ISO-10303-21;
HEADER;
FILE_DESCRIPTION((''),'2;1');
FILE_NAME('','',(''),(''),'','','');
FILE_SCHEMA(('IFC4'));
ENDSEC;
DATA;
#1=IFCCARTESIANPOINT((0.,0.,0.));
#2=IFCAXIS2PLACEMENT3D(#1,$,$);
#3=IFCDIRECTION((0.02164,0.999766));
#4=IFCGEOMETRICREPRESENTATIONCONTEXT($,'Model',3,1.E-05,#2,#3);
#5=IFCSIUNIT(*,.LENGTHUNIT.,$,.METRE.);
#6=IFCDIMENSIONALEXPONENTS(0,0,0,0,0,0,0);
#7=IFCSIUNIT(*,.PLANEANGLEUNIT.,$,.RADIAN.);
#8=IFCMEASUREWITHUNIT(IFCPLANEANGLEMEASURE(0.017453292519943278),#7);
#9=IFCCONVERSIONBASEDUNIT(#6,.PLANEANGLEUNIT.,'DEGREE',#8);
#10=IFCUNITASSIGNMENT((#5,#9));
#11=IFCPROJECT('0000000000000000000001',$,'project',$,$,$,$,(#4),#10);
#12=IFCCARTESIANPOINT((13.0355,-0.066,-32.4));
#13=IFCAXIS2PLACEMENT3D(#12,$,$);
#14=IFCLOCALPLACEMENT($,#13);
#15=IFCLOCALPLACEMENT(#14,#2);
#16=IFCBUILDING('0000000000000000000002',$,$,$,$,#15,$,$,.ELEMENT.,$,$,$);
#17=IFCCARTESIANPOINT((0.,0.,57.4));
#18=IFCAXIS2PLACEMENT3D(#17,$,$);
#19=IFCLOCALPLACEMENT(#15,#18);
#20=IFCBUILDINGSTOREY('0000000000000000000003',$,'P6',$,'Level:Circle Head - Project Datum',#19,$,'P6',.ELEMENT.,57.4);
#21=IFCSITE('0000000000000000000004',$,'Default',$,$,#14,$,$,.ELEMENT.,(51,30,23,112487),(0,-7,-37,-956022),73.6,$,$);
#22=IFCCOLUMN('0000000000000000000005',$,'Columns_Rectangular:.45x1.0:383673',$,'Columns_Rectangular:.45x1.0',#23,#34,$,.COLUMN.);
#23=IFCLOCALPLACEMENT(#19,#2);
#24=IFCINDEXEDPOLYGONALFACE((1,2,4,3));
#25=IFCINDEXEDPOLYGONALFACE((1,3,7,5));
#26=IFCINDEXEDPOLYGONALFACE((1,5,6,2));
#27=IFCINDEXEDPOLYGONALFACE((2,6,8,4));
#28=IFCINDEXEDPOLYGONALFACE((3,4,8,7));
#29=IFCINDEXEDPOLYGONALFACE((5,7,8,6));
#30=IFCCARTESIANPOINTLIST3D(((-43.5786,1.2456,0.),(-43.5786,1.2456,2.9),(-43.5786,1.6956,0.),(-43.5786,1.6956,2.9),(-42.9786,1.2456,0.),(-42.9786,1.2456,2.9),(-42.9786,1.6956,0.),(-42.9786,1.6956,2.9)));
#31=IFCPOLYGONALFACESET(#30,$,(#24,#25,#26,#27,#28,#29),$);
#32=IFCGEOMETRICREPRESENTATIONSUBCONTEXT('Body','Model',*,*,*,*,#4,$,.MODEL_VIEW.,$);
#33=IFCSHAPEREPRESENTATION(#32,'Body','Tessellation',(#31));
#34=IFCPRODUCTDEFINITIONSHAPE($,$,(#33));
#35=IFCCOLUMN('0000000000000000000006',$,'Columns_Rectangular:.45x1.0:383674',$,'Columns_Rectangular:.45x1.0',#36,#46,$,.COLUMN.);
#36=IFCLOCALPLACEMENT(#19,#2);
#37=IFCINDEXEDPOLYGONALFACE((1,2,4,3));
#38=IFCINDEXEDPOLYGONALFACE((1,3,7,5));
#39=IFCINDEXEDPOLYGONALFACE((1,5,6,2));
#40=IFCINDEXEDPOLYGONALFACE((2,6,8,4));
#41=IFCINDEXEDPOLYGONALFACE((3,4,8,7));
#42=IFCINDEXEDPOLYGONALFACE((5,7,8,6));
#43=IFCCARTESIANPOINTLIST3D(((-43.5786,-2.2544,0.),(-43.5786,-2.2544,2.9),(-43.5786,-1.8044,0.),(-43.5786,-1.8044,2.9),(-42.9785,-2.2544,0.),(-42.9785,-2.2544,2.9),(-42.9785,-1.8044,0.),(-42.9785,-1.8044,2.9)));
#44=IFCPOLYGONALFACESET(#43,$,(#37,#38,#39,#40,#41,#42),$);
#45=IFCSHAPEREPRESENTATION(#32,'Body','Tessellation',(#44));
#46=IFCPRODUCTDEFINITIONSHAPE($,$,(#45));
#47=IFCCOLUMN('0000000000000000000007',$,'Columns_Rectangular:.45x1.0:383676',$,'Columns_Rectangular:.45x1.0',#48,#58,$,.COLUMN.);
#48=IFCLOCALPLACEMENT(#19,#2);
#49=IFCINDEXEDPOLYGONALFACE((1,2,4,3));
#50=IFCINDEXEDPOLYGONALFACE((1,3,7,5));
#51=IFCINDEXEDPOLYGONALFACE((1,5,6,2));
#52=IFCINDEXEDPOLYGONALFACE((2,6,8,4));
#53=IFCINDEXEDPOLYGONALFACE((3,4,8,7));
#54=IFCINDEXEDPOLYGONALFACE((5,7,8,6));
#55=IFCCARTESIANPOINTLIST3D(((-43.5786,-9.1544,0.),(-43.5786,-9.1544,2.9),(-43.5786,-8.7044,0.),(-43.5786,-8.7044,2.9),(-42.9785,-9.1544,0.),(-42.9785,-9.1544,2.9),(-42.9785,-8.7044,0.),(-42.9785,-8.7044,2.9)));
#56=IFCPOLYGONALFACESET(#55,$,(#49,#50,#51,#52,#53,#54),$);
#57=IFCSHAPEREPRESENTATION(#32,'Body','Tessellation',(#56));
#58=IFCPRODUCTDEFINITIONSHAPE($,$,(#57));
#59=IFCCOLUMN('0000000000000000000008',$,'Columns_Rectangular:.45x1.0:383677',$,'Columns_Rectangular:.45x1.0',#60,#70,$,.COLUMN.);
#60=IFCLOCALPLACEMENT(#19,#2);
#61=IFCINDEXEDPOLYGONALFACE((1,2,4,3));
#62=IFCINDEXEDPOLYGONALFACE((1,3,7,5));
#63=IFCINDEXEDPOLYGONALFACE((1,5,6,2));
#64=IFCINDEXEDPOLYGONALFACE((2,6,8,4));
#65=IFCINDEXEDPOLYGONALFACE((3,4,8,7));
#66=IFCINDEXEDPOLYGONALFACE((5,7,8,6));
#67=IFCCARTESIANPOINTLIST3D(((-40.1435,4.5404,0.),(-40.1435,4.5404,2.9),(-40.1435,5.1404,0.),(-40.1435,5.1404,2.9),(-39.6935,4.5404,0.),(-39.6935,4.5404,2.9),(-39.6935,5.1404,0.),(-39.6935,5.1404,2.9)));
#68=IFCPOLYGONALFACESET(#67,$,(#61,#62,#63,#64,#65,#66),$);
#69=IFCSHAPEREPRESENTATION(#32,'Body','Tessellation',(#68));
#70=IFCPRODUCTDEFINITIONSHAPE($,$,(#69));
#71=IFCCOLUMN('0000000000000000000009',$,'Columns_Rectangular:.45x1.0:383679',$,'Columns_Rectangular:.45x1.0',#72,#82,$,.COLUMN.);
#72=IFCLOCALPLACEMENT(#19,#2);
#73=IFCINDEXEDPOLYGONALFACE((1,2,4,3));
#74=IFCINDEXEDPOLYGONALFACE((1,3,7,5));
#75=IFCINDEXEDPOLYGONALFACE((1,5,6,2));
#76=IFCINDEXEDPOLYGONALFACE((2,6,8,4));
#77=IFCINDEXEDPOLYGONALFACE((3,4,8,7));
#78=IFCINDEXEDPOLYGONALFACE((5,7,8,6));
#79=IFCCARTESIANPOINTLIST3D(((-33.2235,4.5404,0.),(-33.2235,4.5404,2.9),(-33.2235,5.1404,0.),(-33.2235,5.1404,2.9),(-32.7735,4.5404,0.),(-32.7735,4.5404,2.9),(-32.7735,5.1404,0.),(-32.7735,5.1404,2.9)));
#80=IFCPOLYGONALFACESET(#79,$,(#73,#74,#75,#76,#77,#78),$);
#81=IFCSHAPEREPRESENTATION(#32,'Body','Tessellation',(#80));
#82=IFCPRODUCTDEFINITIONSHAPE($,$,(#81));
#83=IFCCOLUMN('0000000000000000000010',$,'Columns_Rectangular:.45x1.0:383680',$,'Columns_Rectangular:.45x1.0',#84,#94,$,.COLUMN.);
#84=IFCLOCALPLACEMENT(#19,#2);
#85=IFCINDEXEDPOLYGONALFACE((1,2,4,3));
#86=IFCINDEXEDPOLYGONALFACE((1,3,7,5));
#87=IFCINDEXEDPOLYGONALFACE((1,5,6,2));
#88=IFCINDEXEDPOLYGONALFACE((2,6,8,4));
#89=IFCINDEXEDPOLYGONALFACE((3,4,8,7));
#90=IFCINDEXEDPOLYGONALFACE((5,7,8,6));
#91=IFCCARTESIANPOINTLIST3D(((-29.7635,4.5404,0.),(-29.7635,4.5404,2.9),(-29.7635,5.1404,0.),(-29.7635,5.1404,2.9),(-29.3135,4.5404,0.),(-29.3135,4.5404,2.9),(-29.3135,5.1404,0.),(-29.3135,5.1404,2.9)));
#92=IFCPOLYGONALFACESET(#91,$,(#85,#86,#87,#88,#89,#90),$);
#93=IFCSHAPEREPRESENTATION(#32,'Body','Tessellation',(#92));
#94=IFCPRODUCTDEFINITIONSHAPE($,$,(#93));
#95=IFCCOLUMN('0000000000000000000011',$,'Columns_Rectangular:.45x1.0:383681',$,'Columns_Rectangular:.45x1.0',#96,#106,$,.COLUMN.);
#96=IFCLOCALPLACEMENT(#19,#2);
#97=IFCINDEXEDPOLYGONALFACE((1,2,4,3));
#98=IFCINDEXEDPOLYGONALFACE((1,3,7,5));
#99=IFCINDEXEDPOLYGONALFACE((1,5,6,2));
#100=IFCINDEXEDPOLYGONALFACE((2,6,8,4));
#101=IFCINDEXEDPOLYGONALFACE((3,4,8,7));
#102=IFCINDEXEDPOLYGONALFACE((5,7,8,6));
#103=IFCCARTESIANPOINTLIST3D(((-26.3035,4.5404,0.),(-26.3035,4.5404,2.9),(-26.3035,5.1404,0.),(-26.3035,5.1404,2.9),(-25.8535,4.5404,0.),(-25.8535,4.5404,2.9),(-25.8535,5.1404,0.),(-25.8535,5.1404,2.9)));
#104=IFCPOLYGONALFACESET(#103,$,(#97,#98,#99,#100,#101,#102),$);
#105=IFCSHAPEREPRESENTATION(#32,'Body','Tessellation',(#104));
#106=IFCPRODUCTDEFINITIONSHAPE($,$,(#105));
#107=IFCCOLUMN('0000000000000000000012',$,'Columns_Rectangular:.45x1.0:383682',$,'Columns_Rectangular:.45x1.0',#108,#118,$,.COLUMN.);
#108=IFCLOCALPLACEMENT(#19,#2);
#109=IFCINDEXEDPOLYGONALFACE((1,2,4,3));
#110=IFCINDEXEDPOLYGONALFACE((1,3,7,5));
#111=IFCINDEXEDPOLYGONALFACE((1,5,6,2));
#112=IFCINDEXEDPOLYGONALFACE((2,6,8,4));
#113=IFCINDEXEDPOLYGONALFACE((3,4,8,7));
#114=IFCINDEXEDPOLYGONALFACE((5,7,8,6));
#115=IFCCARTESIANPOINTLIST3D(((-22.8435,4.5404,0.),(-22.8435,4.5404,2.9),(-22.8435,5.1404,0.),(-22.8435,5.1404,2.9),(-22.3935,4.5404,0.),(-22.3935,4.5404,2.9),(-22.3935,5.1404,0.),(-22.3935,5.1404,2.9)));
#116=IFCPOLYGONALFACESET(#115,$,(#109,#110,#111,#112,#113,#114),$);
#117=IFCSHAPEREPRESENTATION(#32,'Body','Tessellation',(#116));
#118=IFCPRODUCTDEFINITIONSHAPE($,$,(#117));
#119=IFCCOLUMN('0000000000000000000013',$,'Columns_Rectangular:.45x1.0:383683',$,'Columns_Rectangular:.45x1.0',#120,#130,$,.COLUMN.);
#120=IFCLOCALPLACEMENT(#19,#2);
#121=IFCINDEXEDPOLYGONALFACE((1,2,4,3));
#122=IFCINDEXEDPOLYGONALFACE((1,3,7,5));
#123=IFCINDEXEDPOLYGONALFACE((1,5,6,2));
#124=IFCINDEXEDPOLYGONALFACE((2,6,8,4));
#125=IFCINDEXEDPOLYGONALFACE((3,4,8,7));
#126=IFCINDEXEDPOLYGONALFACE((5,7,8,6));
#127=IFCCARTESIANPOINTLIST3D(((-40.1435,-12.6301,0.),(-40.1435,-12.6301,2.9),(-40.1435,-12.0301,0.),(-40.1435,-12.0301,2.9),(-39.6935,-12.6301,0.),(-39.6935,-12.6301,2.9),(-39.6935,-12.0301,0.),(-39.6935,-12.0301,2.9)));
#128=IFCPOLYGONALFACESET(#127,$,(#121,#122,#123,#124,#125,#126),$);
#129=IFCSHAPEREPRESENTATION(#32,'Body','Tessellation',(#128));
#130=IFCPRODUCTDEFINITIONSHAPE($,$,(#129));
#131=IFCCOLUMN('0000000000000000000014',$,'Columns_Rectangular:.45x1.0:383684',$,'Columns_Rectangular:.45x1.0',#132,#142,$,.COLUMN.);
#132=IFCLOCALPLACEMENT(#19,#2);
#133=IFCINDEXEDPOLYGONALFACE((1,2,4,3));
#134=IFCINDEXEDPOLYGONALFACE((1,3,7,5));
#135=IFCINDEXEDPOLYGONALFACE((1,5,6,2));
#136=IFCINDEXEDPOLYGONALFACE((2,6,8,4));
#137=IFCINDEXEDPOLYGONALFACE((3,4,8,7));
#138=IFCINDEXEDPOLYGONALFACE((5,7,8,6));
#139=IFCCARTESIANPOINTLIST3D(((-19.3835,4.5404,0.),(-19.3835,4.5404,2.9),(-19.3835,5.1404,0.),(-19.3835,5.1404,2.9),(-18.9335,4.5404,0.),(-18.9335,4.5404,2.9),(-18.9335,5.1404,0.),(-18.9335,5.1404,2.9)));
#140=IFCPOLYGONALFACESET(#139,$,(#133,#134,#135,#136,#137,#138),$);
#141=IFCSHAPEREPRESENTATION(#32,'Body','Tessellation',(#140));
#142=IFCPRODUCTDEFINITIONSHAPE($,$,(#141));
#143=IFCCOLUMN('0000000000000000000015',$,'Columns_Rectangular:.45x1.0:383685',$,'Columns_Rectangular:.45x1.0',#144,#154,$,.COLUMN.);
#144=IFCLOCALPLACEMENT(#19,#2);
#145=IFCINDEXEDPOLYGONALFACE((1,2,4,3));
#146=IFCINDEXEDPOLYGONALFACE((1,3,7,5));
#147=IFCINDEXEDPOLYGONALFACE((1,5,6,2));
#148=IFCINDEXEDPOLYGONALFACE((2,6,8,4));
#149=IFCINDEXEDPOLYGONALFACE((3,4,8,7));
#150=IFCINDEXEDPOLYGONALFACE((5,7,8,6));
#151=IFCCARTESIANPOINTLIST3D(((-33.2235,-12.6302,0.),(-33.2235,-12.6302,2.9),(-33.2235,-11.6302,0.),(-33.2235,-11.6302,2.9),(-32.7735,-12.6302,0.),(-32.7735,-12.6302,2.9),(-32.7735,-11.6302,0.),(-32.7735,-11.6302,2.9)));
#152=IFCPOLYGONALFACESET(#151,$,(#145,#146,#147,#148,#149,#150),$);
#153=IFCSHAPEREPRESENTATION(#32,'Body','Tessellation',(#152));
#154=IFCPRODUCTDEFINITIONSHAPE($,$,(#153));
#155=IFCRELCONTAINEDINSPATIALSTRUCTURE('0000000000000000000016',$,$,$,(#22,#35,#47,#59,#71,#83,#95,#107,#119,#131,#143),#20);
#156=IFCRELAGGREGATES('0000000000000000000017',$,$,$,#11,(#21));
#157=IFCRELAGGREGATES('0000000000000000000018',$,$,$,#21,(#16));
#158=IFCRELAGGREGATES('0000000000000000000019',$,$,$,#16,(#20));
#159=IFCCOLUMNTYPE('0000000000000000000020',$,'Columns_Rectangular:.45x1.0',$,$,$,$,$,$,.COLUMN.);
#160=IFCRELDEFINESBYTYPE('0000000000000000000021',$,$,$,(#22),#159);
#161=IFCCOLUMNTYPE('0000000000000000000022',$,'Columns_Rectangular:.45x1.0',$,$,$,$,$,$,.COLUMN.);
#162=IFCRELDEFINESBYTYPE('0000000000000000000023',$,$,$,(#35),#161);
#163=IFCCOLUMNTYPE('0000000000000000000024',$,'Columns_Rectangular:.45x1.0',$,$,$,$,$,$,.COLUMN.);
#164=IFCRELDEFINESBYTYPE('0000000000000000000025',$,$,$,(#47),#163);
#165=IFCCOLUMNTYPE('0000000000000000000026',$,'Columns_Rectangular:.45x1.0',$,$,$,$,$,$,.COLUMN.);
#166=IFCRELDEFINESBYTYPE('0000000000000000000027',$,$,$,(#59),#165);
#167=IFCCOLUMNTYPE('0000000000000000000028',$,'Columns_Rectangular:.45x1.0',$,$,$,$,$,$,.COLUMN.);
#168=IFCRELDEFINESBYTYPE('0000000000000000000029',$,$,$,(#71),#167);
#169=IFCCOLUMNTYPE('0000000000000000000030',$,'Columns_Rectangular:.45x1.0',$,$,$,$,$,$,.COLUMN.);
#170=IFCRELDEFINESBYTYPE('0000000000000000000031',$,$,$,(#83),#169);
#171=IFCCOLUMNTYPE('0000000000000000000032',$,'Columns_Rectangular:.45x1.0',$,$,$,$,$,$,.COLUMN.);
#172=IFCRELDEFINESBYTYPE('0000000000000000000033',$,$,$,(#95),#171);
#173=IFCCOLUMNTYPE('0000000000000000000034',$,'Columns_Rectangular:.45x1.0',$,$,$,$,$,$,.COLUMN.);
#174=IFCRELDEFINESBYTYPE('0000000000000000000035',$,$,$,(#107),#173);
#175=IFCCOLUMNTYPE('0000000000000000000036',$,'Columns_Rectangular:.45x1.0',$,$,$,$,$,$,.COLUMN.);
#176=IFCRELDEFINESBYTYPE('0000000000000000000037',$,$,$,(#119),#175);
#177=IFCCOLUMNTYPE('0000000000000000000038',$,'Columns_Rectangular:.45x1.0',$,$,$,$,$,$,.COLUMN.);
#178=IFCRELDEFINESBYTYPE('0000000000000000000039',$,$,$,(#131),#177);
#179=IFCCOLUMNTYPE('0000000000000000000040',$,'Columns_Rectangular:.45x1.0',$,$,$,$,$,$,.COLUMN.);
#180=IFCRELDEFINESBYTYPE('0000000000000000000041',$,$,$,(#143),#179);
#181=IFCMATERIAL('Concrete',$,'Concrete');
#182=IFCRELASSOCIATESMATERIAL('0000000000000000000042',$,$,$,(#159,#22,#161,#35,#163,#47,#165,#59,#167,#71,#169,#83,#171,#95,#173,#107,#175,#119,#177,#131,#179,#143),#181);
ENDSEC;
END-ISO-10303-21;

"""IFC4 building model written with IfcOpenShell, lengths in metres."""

from ifc_helpers import new_model, entity, si_unit, converted_unit, direction, frame, origin, place, context, subcontext, project, spatial, indexed_curve, outline, extrude, source, transform, mapped, material, type_object, type_shapes, element, save


model = new_model("IFC4")

# Units and contexts
model_context = context("Model", 3, precision=1e-05, world=origin(), true_north=direction((0.02164, 0.999766)))
body_context = subcontext(model_context, "Body", "Model", "MODEL_VIEW")
ifc_project = project(units=[si_unit("LENGTHUNIT", "METRE"), converted_unit("PLANEANGLEUNIT", "DEGREE", entity("IfcPlaneAngleMeasure", 0.017453292519943278), si_unit("PLANEANGLEUNIT", "RADIAN"), dimensions=[0, 0, 0, 0, 0, 0, 0])], contexts=[model_context])

# Site, building, storey
site_placement = place(None, frame((13.0355, -0.066, -32.4)))
site = spatial("IfcSite", under=ifc_project, at=site_placement, Name="Default", CompositionType="ELEMENT", RefLatitude=(51, 30, 23, 112487), RefLongitude=(0, -7, -37, -956022), RefElevation=73.6)
building_placement = place(site_placement, origin())
building = spatial("IfcBuilding", under=site, at=building_placement, CompositionType="ELEMENT")
storey_placement = place(building_placement, frame((0.0, 0.0, 57.4)))
storey = spatial("IfcBuildingStorey", under=building, at=storey_placement, Name="P6", ObjectType="Level:Circle Head - Project Datum", LongName="P6", CompositionType="ELEMENT", Elevation=57.4)

# Columns
ifc_material = material(Name="Concrete", Category="Concrete")
column_type_1 = type_object("IfcColumnType", Name="Columns_Rectangular:.45x1.0", PredefinedType="COLUMN", material=ifc_material)
shared_shape_1 = source(origin(), body_context, "Body", "SweptSolid", [
    extrude(outline(indexed_curve([(-0.3, -0.225), (0.3, -0.225), (0.3, 0.225), (-0.3, 0.225), (-0.3, -0.225)], self_intersect=False)), frame((-43.2786, 1.4706, 57.4)), (0.0, 0.0, 1.0), 2.9),
])
type_shapes(column_type_1, [shared_shape_1])
column_1_placement = place(storey_placement, frame((0.0, 0.0, -57.4)))
element("IfcColumn", 1, at=column_1_placement, inside=storey, type_object=column_type_1, material=ifc_material, Name="Columns_Rectangular:.45x1.0:383673", ObjectType="Columns_Rectangular:.45x1.0", PredefinedType="COLUMN", context=body_context, shape_type="MappedRepresentation", body=[
    mapped(shared_shape_1, transform((0.0, 0.0, 0.0), scale=1.0)),
])
column_type_2 = type_object("IfcColumnType", Name="Columns_Rectangular:.45x1.0", PredefinedType="COLUMN", material=ifc_material)
shared_shape_2 = source(origin(), body_context, "Body", "SweptSolid", [
    extrude(outline(indexed_curve([(-0.3, -0.225), (0.3, -0.225), (0.3, 0.225), (-0.3, 0.225), (-0.3, -0.225)], self_intersect=False)), frame((-43.2785, -2.0294, 57.4)), (0.0, 0.0, 1.0), 2.9),
])
type_shapes(column_type_2, [shared_shape_2])
column_2_placement = place(storey_placement, frame((0.0, 0.0, -57.4)))
element("IfcColumn", 2, at=column_2_placement, inside=storey, type_object=column_type_2, material=ifc_material, Name="Columns_Rectangular:.45x1.0:383674", ObjectType="Columns_Rectangular:.45x1.0", PredefinedType="COLUMN", context=body_context, shape_type="MappedRepresentation", body=[
    mapped(shared_shape_2, transform((0.0, 0.0, 0.0), scale=1.0)),
])
column_type_3 = type_object("IfcColumnType", Name="Columns_Rectangular:.45x1.0", PredefinedType="COLUMN", material=ifc_material)
shared_shape_3 = source(origin(), body_context, "Body", "SweptSolid", [
    extrude(outline(indexed_curve([(-0.3, -0.225), (0.3, -0.225), (0.3, 0.225), (-0.3, 0.225), (-0.3, -0.225)], self_intersect=False)), frame((-43.2785, -8.9294, 57.4)), (0.0, 0.0, 1.0), 2.9),
])
type_shapes(column_type_3, [shared_shape_3])
column_3_placement = place(storey_placement, frame((0.0, 0.0, -57.4)))
element("IfcColumn", 3, at=column_3_placement, inside=storey, type_object=column_type_3, material=ifc_material, Name="Columns_Rectangular:.45x1.0:383676", ObjectType="Columns_Rectangular:.45x1.0", PredefinedType="COLUMN", context=body_context, shape_type="MappedRepresentation", body=[
    mapped(shared_shape_3, transform((0.0, 0.0, 0.0), scale=1.0)),
])
column_type_4 = type_object("IfcColumnType", Name="Columns_Rectangular:.45x1.0", PredefinedType="COLUMN", material=ifc_material)
shared_shape_4 = source(origin(), body_context, "Body", "SweptSolid", [
    extrude(outline(indexed_curve([(-0.3, -0.225), (0.3, -0.225), (0.3, 0.225), (-0.3, 0.225), (-0.3, -0.225)], self_intersect=False)), frame((-39.9185, 4.8404, 57.4), z_axis=(0.0, 0.0, 1.0), x_axis=(0.0, -1.0, 0.0)), (0.0, 0.0, 1.0), 2.9),
])
type_shapes(column_type_4, [shared_shape_4])
column_4_placement = place(storey_placement, frame((0.0, 0.0, -57.4)))
element("IfcColumn", 4, at=column_4_placement, inside=storey, type_object=column_type_4, material=ifc_material, Name="Columns_Rectangular:.45x1.0:383677", ObjectType="Columns_Rectangular:.45x1.0", PredefinedType="COLUMN", context=body_context, shape_type="MappedRepresentation", body=[
    mapped(shared_shape_4, transform((0.0, 0.0, 0.0), scale=1.0)),
])
column_type_5 = type_object("IfcColumnType", Name="Columns_Rectangular:.45x1.0", PredefinedType="COLUMN", material=ifc_material)
shared_shape_5 = source(origin(), body_context, "Body", "SweptSolid", [
    extrude(outline(indexed_curve([(-0.3, -0.225), (0.3, -0.225), (0.3, 0.225), (-0.3, 0.225), (-0.3, -0.225)], self_intersect=False)), frame((-32.9985, 4.8404, 57.4), z_axis=(0.0, 0.0, 1.0), x_axis=(0.0, -1.0, 0.0)), (0.0, 0.0, 1.0), 2.9),
])
type_shapes(column_type_5, [shared_shape_5])
column_5_placement = place(storey_placement, frame((0.0, 0.0, -57.4)))
element("IfcColumn", 5, at=column_5_placement, inside=storey, type_object=column_type_5, material=ifc_material, Name="Columns_Rectangular:.45x1.0:383679", ObjectType="Columns_Rectangular:.45x1.0", PredefinedType="COLUMN", context=body_context, shape_type="MappedRepresentation", body=[
    mapped(shared_shape_5, transform((0.0, 0.0, 0.0), scale=1.0)),
])
column_type_6 = type_object("IfcColumnType", Name="Columns_Rectangular:.45x1.0", PredefinedType="COLUMN", material=ifc_material)
shared_shape_6 = source(origin(), body_context, "Body", "SweptSolid", [
    extrude(outline(indexed_curve([(-0.3, -0.225), (0.3, -0.225), (0.3, 0.225), (-0.3, 0.225), (-0.3, -0.225)], self_intersect=False)), frame((-29.5385, 4.8404, 57.4), z_axis=(0.0, 0.0, 1.0), x_axis=(0.0, -1.0, 0.0)), (0.0, 0.0, 1.0), 2.9),
])
type_shapes(column_type_6, [shared_shape_6])
column_6_placement = place(storey_placement, frame((0.0, 0.0, -57.4)))
element("IfcColumn", 6, at=column_6_placement, inside=storey, type_object=column_type_6, material=ifc_material, Name="Columns_Rectangular:.45x1.0:383680", ObjectType="Columns_Rectangular:.45x1.0", PredefinedType="COLUMN", context=body_context, shape_type="MappedRepresentation", body=[
    mapped(shared_shape_6, transform((0.0, 0.0, 0.0), scale=1.0)),
])
column_type_7 = type_object("IfcColumnType", Name="Columns_Rectangular:.45x1.0", PredefinedType="COLUMN", material=ifc_material)
shared_shape_7 = source(origin(), body_context, "Body", "SweptSolid", [
    extrude(outline(indexed_curve([(-0.3, -0.225), (0.3, -0.225), (0.3, 0.225), (-0.3, 0.225), (-0.3, -0.225)], self_intersect=False)), frame((-26.0785, 4.8404, 57.4), z_axis=(0.0, 0.0, 1.0), x_axis=(0.0, -1.0, 0.0)), (0.0, 0.0, 1.0), 2.9),
])
type_shapes(column_type_7, [shared_shape_7])
column_7_placement = place(storey_placement, frame((0.0, 0.0, -57.4)))
element("IfcColumn", 7, at=column_7_placement, inside=storey, type_object=column_type_7, material=ifc_material, Name="Columns_Rectangular:.45x1.0:383681", ObjectType="Columns_Rectangular:.45x1.0", PredefinedType="COLUMN", context=body_context, shape_type="MappedRepresentation", body=[
    mapped(shared_shape_7, transform((0.0, 0.0, 0.0), scale=1.0)),
])
column_type_8 = type_object("IfcColumnType", Name="Columns_Rectangular:.45x1.0", PredefinedType="COLUMN", material=ifc_material)
shared_shape_8 = source(origin(), body_context, "Body", "SweptSolid", [
    extrude(outline(indexed_curve([(-0.3, -0.225), (0.3, -0.225), (0.3, 0.225), (-0.3, 0.225), (-0.3, -0.225)], self_intersect=False)), frame((-22.6185, 4.8404, 57.4), z_axis=(0.0, 0.0, 1.0), x_axis=(0.0, -1.0, 0.0)), (0.0, 0.0, 1.0), 2.9),
])
type_shapes(column_type_8, [shared_shape_8])
column_8_placement = place(storey_placement, frame((0.0, 0.0, -57.4)))
element("IfcColumn", 8, at=column_8_placement, inside=storey, type_object=column_type_8, material=ifc_material, Name="Columns_Rectangular:.45x1.0:383682", ObjectType="Columns_Rectangular:.45x1.0", PredefinedType="COLUMN", context=body_context, shape_type="MappedRepresentation", body=[
    mapped(shared_shape_8, transform((0.0, 0.0, 0.0), scale=1.0)),
])
column_type_9 = type_object("IfcColumnType", Name="Columns_Rectangular:.45x1.0", PredefinedType="COLUMN", material=ifc_material)
shared_shape_9 = source(origin(), body_context, "Body", "SweptSolid", [
    extrude(outline(indexed_curve([(-0.3, -0.225), (0.3, -0.225), (0.3, 0.225), (-0.3, 0.225), (-0.3, -0.225)], self_intersect=False)), frame((-39.9185, -12.3301, 57.4), z_axis=(0.0, 0.0, 1.0), x_axis=(0.000011, 1.0, 0.0)), (0.0, 0.0, 1.0), 2.9),
])
type_shapes(column_type_9, [shared_shape_9])
column_9_placement = place(storey_placement, frame((0.0, 0.0, -57.4)))
element("IfcColumn", 9, at=column_9_placement, inside=storey, type_object=column_type_9, material=ifc_material, Name="Columns_Rectangular:.45x1.0:383683", ObjectType="Columns_Rectangular:.45x1.0", PredefinedType="COLUMN", context=body_context, shape_type="MappedRepresentation", body=[
    mapped(shared_shape_9, transform((0.0, 0.0, 0.0), scale=1.0)),
])
column_type_10 = type_object("IfcColumnType", Name="Columns_Rectangular:.45x1.0", PredefinedType="COLUMN", material=ifc_material)
shared_shape_10 = source(origin(), body_context, "Body", "SweptSolid", [
    extrude(outline(indexed_curve([(-0.3, -0.225), (0.3, -0.225), (0.3, 0.225), (-0.3, 0.225), (-0.3, -0.225)], self_intersect=False)), frame((-19.1585, 4.8404, 57.4), z_axis=(0.0, 0.0, 1.0), x_axis=(0.0, -1.0, 0.0)), (0.0, 0.0, 1.0), 2.9),
])
type_shapes(column_type_10, [shared_shape_10])
column_10_placement = place(storey_placement, frame((0.0, 0.0, -57.4)))
element("IfcColumn", 10, at=column_10_placement, inside=storey, type_object=column_type_10, material=ifc_material, Name="Columns_Rectangular:.45x1.0:383684", ObjectType="Columns_Rectangular:.45x1.0", PredefinedType="COLUMN", context=body_context, shape_type="MappedRepresentation", body=[
    mapped(shared_shape_10, transform((0.0, 0.0, 0.0), scale=1.0)),
])
column_type_11 = type_object("IfcColumnType", Name="Columns_Rectangular:.45x1.0", PredefinedType="COLUMN", material=ifc_material)
shared_shape_11 = source(origin(), body_context, "Body", "SweptSolid", [
    extrude(outline(indexed_curve([(-0.5, -0.225), (0.5, -0.225), (0.5, 0.225), (-0.5, 0.225), (-0.5, -0.225)], self_intersect=False)), frame((-32.9985, -12.1302, 57.4), z_axis=(0.0, 0.0, 1.0), x_axis=(0.000011, 1.0, 0.0)), (0.0, 0.0, 1.0), 2.9),
])
type_shapes(column_type_11, [shared_shape_11])
column_11_placement = place(storey_placement, frame((0.0, 0.0, -57.4)))
element("IfcColumn", 11, at=column_11_placement, inside=storey, type_object=column_type_11, material=ifc_material, Name="Columns_Rectangular:.45x1.0:383685", ObjectType="Columns_Rectangular:.45x1.0", PredefinedType="COLUMN", context=body_context, shape_type="MappedRepresentation", body=[
    mapped(shared_shape_11, transform((0.0, 0.0, 0.0), scale=1.0)),
])

save(model, "model.ifc")
